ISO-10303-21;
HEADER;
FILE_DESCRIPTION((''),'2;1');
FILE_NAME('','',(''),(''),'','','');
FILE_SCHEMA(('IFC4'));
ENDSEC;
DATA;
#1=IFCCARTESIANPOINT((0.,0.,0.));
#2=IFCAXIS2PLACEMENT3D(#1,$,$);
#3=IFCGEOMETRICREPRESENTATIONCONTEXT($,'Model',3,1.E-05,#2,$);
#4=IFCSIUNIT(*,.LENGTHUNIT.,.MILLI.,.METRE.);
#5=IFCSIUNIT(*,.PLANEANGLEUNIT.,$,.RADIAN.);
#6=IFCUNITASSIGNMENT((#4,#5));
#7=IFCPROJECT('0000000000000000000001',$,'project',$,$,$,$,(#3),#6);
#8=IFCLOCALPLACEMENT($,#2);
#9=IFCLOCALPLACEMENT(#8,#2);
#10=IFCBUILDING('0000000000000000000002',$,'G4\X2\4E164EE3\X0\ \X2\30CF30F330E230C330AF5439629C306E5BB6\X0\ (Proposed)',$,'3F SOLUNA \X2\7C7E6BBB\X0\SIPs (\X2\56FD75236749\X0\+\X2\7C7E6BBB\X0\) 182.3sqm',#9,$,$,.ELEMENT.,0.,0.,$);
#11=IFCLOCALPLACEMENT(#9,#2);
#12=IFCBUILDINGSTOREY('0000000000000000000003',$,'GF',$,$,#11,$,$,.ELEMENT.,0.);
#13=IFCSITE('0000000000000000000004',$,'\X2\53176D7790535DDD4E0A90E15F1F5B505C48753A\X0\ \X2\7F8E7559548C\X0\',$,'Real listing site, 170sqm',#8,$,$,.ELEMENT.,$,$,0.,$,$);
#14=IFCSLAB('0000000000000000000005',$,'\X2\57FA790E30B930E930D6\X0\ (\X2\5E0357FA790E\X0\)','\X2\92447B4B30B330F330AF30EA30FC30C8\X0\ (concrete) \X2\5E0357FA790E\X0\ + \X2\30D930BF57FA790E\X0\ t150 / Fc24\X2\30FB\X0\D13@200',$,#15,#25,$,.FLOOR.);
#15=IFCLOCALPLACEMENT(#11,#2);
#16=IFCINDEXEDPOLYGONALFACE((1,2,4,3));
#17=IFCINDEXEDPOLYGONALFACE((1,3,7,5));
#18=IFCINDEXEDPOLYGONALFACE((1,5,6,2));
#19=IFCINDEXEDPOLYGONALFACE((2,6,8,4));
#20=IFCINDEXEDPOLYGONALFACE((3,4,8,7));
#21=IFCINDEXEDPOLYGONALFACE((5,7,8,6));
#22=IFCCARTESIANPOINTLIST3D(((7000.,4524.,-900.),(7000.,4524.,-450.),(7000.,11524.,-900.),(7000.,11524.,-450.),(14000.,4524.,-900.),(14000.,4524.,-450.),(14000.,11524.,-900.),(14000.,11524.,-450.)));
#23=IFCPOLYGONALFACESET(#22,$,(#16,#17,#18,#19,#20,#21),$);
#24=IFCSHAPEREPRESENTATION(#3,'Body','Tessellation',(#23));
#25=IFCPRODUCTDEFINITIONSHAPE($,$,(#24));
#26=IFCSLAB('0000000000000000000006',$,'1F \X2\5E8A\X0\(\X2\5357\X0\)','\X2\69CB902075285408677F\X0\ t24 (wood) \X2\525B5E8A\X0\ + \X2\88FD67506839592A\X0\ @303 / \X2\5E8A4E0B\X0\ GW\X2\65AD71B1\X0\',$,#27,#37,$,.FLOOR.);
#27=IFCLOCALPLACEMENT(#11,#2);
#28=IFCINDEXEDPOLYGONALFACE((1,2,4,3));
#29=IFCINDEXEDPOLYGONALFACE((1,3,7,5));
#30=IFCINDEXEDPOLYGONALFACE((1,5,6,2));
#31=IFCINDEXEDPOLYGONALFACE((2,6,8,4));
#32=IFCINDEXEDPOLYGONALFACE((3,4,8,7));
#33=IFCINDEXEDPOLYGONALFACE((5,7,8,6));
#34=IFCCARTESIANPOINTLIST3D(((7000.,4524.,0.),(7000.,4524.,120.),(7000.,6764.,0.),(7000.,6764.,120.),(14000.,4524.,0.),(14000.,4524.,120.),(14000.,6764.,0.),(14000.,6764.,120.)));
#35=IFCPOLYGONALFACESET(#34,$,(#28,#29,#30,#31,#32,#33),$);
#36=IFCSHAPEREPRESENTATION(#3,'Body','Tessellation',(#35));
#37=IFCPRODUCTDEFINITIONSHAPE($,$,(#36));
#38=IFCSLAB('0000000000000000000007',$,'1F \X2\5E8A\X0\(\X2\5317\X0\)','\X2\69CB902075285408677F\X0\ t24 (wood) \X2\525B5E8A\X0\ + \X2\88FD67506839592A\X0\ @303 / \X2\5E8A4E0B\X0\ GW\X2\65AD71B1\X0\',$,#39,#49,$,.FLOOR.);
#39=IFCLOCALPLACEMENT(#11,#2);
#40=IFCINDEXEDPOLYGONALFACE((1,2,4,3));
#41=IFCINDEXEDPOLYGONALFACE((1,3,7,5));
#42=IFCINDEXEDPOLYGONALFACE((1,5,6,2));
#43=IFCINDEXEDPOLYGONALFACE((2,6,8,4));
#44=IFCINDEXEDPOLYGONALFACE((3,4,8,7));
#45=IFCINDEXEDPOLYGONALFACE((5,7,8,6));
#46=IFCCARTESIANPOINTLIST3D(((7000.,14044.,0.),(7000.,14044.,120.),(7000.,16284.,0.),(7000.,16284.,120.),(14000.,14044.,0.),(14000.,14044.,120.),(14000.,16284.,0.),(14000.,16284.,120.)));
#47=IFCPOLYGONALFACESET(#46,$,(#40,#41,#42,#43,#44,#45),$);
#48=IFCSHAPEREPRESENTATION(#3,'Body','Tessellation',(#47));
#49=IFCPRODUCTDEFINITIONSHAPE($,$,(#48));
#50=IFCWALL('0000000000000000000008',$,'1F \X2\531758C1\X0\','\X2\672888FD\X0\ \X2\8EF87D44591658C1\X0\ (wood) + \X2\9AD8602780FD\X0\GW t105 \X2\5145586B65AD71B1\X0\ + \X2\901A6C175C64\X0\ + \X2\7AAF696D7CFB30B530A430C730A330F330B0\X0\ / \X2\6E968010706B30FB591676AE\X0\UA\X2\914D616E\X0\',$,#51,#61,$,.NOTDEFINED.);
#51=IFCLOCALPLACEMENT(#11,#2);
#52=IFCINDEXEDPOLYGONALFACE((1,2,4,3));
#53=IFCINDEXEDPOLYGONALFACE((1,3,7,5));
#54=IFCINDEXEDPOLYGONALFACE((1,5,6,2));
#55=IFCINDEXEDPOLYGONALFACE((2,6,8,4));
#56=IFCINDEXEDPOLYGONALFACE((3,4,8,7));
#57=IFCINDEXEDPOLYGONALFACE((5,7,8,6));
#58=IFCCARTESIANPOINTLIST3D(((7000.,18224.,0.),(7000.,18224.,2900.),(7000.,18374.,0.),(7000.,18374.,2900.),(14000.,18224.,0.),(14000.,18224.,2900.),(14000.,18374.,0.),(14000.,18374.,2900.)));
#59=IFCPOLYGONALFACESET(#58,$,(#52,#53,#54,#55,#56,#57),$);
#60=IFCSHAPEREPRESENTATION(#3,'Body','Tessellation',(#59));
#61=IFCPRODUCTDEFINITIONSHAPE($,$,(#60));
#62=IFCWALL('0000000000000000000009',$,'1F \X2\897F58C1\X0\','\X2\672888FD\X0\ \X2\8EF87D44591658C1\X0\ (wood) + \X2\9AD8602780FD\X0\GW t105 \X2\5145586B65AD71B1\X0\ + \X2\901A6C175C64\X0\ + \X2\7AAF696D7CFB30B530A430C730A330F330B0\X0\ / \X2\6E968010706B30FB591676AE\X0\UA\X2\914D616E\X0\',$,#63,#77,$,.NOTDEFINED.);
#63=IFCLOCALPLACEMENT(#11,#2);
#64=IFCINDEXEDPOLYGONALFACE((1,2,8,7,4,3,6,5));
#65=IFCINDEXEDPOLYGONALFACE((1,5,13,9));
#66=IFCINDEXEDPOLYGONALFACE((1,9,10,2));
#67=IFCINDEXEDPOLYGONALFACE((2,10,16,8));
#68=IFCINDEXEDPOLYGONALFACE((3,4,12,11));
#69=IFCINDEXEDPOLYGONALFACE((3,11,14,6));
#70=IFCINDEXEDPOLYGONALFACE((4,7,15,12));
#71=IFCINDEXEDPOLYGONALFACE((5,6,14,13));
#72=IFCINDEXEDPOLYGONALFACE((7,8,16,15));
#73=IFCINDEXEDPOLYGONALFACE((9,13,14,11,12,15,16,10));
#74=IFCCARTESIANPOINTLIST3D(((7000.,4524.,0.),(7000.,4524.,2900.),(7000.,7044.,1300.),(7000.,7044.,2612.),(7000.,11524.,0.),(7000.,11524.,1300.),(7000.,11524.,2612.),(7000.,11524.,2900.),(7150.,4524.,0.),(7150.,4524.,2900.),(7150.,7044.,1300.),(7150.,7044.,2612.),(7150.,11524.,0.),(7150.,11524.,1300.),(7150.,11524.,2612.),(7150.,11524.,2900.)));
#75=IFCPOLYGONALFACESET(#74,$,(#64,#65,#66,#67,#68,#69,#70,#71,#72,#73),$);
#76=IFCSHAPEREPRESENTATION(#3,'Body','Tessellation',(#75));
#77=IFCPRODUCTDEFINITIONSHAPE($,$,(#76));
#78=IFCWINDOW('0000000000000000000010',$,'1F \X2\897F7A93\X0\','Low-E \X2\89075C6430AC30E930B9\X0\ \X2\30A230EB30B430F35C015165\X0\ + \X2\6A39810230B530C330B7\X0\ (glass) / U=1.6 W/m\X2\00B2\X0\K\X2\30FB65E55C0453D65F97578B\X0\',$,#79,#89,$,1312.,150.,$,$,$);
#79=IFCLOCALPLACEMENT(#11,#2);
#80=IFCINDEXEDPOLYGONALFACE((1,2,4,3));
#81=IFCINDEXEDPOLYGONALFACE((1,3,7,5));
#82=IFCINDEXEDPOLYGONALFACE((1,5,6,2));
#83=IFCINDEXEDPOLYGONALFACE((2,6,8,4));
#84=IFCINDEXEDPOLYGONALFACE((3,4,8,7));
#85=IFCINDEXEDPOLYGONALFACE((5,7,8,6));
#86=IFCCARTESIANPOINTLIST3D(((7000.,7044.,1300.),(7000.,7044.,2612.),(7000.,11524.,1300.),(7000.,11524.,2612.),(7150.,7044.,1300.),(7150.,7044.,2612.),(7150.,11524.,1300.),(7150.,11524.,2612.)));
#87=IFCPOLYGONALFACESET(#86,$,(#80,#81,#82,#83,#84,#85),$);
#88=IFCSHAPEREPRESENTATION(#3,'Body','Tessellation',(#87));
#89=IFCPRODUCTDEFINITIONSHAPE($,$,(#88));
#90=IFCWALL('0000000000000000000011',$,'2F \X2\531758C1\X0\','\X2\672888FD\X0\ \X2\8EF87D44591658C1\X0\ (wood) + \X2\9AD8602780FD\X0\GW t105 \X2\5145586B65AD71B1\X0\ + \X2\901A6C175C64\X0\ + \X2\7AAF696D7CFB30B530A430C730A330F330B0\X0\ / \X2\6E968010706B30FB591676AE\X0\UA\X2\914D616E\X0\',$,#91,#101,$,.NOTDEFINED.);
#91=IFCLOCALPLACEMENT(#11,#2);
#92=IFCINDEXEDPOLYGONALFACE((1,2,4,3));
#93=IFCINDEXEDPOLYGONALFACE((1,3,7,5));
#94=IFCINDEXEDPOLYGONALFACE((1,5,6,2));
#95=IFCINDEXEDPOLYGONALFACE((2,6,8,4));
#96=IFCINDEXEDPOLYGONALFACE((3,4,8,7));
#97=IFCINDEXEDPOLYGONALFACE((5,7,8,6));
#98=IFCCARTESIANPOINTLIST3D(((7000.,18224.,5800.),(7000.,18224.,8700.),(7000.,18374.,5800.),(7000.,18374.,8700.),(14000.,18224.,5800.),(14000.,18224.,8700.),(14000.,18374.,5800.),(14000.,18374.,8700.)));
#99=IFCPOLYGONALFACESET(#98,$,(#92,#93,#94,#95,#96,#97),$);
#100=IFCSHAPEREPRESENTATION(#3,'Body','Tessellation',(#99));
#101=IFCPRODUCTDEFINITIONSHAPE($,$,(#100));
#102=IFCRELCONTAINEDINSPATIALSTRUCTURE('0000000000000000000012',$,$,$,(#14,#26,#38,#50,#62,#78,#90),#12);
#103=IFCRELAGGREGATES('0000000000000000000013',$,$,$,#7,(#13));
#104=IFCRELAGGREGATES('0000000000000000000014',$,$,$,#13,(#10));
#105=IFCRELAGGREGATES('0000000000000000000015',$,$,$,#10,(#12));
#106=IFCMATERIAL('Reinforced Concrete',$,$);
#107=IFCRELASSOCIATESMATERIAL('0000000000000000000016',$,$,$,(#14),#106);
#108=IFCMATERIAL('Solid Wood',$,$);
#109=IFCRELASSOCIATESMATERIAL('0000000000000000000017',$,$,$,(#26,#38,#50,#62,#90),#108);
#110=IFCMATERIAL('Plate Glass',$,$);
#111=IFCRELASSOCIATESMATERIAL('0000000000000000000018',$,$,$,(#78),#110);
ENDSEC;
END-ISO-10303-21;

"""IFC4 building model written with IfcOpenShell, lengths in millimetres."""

from ifc_helpers import new_model, si_unit, frame, frame_2d, origin, place, context, project, spatial, rectangle, extrude, material, element, fill, save


model = new_model("IFC4")

# Units and contexts
model_context = context("Model", 3, precision=1e-05, world=origin())
ifc_project = project(units=[si_unit("LENGTHUNIT", "METRE", prefix="MILLI"), si_unit("PLANEANGLEUNIT", "RADIAN")], contexts=[model_context])

# Site, building, storey
site_placement = place(None, origin())
site = spatial("IfcSite", under=ifc_project, at=site_placement, Name="北海道川上郡弟子屈町 美留和", ObjectType="Real listing site, 170sqm", CompositionType="ELEMENT", RefElevation=0.0)
building_placement = place(site_placement, origin())
building = spatial("IfcBuilding", under=site, at=building_placement, Name="G4世代 ハンモック吹抜の家 (Proposed)", ObjectType="3F SOLUNA 籾殻SIPs (国産杉+籾殻) 182.3sqm", CompositionType="ELEMENT", ElevationOfRefHeight=0.0, ElevationOfTerrain=0.0)
storey_placement = place(building_placement, origin())
storey = spatial("IfcBuildingStorey", under=building, at=storey_placement, Name="GF", CompositionType="ELEMENT", Elevation=0.0)

# Slabs
ifc_material_1 = material(Name="Reinforced Concrete")
slab_1_placement = place(storey_placement, frame((3500.0, 2262.0, -450.0)))
element("IfcSlab", 1, at=slab_1_placement, inside=storey, material=ifc_material_1, Name="基礎スラブ (布基礎)", Description="鉄筋コンクリート (concrete) 布基礎 + ベタ基礎 t150 / Fc24・D13@200", PredefinedType="FLOOR", context=model_context, shape_type="SweptSolid", body=[
    extrude(rectangle(XDim=7000.0, YDim=7000.0, at=frame_2d((3500.0, 3500.0))), frame((3500.0, 2262.0, -450.0)), (0.0, 0.0, 1.0), 450.0),
])
ifc_material_2 = material(Name="Solid Wood")
slab_2_placement = place(storey_placement, frame((3500.0, 2262.0, 0.0)))
element("IfcSlab", 2, at=slab_2_placement, inside=storey, material=ifc_material_2, Name="1F 床(南)", Description="構造用合板 t24 (wood) 剛床 + 製材根太 @303 / 床下 GW断熱", PredefinedType="FLOOR", context=model_context, shape_type="SweptSolid", body=[
    extrude(rectangle(XDim=7000.0, YDim=2240.0, at=frame_2d((3500.0, 1120.0))), frame((3500.0, 2262.0, 0.0)), (0.0, 0.0, 1.0), 120.0),
])
slab_3_placement = place(storey_placement, frame((3500.0, 7022.0, 0.0)))
element("IfcSlab", 3, at=slab_3_placement, inside=storey, material=ifc_material_2, Name="1F 床(北)", Description="構造用合板 t24 (wood) 剛床 + 製材根太 @303 / 床下 GW断熱", PredefinedType="FLOOR", context=model_context, shape_type="SweptSolid", body=[
    extrude(rectangle(XDim=7000.0, YDim=2240.0, at=frame_2d((3500.0, 1120.0))), frame((3500.0, 7022.0, 0.0)), (0.0, 0.0, 1.0), 120.0),
])

# Shared definitions
ifc_material_3 = material(Name="Plate Glass")

# Wall
wall_1_placement = place(storey_placement, frame((3500.0, 9112.0, 0.0)))
element("IfcWall", 4, at=wall_1_placement, inside=storey, material=ifc_material_2, Name="1F 北壁", Description="木製 軸組外壁 (wood) + 高性能GW t105 充填断熱 + 通気層 + 窯業系サイディング / 準耐火・外皮UA配慮", PredefinedType="NOTDEFINED", context=model_context, shape_type="SweptSolid", body=[
    extrude(rectangle(XDim=7000.0, YDim=150.0, at=frame_2d((3500.0, 75.0))), frame((3500.0, 9112.0, 0.0)), (0.0, 0.0, 1.0), 2900.0),
])

# Wall, opening, window
wall_2_placement = place(storey_placement, frame((3500.0, 2262.0, 0.0)))
wall_2 = element("IfcWall", 5, at=wall_2_placement, inside=storey, material=ifc_material_2, Name="1F 西壁", Description="木製 軸組外壁 (wood) + 高性能GW t105 充填断熱 + 通気層 + 窯業系サイディング / 準耐火・外皮UA配慮", PredefinedType="NOTDEFINED", context=model_context, shape_type="SweptSolid", body=[
    extrude(rectangle(XDim=150.0, YDim=7000.0, at=frame_2d((75.0, 3500.0))), frame((3500.0, 2262.0, 0.0)), (0.0, 0.0, 1.0), 2900.0),
])
opening_1_placement = place(storey_placement, frame((3500.0, 3522.0, 650.0)))
opening_1 = element("IfcOpeningElement", 6, at=opening_1_placement, cuts=wall_2, PredefinedType="NOTDEFINED", context=model_context, shape_type="SweptSolid", body=[
    extrude(rectangle(XDim=150.0, YDim=4480.0, at=frame_2d((75.0, 2240.0))), frame((3500.0, 3522.0, 650.0)), (0.0, 0.0, 1.0), 1312.0),
])
window_1_placement = place(storey_placement, frame((3500.0, 3522.0, 650.0)))
window_1 = element("IfcWindow", 7, at=window_1_placement, inside=storey, material=ifc_material_3, Name="1F 西窓", Description="Low-E 複層ガラス アルゴン封入 + 樹脂サッシ (glass) / U=1.6 W/m²K・日射取得型", OverallHeight=1312.0, OverallWidth=150.0, context=model_context, shape_type="SweptSolid", body=[
    extrude(rectangle(XDim=150.0, YDim=4480.0, at=frame_2d((75.0, 2240.0))), frame((3500.0, 3522.0, 650.0)), (0.0, 0.0, 1.0), 1312.0),
])
fill(opening_1, window_1)

# Wall
wall_3_placement = place(storey_placement, frame((3500.0, 9112.0, 2900.0)))
element("IfcWall", 8, at=wall_3_placement, inside=storey, material=ifc_material_2, Name="2F 北壁", Description="木製 軸組外壁 (wood) + 高性能GW t105 充填断熱 + 通気層 + 窯業系サイディング / 準耐火・外皮UA配慮", PredefinedType="NOTDEFINED", context=model_context, shape_type="SweptSolid", body=[
    extrude(rectangle(XDim=7000.0, YDim=150.0, at=frame_2d((3500.0, 75.0))), frame((3500.0, 9112.0, 2900.0)), (0.0, 0.0, 1.0), 2900.0),
])

save(model, "model.ifc")
